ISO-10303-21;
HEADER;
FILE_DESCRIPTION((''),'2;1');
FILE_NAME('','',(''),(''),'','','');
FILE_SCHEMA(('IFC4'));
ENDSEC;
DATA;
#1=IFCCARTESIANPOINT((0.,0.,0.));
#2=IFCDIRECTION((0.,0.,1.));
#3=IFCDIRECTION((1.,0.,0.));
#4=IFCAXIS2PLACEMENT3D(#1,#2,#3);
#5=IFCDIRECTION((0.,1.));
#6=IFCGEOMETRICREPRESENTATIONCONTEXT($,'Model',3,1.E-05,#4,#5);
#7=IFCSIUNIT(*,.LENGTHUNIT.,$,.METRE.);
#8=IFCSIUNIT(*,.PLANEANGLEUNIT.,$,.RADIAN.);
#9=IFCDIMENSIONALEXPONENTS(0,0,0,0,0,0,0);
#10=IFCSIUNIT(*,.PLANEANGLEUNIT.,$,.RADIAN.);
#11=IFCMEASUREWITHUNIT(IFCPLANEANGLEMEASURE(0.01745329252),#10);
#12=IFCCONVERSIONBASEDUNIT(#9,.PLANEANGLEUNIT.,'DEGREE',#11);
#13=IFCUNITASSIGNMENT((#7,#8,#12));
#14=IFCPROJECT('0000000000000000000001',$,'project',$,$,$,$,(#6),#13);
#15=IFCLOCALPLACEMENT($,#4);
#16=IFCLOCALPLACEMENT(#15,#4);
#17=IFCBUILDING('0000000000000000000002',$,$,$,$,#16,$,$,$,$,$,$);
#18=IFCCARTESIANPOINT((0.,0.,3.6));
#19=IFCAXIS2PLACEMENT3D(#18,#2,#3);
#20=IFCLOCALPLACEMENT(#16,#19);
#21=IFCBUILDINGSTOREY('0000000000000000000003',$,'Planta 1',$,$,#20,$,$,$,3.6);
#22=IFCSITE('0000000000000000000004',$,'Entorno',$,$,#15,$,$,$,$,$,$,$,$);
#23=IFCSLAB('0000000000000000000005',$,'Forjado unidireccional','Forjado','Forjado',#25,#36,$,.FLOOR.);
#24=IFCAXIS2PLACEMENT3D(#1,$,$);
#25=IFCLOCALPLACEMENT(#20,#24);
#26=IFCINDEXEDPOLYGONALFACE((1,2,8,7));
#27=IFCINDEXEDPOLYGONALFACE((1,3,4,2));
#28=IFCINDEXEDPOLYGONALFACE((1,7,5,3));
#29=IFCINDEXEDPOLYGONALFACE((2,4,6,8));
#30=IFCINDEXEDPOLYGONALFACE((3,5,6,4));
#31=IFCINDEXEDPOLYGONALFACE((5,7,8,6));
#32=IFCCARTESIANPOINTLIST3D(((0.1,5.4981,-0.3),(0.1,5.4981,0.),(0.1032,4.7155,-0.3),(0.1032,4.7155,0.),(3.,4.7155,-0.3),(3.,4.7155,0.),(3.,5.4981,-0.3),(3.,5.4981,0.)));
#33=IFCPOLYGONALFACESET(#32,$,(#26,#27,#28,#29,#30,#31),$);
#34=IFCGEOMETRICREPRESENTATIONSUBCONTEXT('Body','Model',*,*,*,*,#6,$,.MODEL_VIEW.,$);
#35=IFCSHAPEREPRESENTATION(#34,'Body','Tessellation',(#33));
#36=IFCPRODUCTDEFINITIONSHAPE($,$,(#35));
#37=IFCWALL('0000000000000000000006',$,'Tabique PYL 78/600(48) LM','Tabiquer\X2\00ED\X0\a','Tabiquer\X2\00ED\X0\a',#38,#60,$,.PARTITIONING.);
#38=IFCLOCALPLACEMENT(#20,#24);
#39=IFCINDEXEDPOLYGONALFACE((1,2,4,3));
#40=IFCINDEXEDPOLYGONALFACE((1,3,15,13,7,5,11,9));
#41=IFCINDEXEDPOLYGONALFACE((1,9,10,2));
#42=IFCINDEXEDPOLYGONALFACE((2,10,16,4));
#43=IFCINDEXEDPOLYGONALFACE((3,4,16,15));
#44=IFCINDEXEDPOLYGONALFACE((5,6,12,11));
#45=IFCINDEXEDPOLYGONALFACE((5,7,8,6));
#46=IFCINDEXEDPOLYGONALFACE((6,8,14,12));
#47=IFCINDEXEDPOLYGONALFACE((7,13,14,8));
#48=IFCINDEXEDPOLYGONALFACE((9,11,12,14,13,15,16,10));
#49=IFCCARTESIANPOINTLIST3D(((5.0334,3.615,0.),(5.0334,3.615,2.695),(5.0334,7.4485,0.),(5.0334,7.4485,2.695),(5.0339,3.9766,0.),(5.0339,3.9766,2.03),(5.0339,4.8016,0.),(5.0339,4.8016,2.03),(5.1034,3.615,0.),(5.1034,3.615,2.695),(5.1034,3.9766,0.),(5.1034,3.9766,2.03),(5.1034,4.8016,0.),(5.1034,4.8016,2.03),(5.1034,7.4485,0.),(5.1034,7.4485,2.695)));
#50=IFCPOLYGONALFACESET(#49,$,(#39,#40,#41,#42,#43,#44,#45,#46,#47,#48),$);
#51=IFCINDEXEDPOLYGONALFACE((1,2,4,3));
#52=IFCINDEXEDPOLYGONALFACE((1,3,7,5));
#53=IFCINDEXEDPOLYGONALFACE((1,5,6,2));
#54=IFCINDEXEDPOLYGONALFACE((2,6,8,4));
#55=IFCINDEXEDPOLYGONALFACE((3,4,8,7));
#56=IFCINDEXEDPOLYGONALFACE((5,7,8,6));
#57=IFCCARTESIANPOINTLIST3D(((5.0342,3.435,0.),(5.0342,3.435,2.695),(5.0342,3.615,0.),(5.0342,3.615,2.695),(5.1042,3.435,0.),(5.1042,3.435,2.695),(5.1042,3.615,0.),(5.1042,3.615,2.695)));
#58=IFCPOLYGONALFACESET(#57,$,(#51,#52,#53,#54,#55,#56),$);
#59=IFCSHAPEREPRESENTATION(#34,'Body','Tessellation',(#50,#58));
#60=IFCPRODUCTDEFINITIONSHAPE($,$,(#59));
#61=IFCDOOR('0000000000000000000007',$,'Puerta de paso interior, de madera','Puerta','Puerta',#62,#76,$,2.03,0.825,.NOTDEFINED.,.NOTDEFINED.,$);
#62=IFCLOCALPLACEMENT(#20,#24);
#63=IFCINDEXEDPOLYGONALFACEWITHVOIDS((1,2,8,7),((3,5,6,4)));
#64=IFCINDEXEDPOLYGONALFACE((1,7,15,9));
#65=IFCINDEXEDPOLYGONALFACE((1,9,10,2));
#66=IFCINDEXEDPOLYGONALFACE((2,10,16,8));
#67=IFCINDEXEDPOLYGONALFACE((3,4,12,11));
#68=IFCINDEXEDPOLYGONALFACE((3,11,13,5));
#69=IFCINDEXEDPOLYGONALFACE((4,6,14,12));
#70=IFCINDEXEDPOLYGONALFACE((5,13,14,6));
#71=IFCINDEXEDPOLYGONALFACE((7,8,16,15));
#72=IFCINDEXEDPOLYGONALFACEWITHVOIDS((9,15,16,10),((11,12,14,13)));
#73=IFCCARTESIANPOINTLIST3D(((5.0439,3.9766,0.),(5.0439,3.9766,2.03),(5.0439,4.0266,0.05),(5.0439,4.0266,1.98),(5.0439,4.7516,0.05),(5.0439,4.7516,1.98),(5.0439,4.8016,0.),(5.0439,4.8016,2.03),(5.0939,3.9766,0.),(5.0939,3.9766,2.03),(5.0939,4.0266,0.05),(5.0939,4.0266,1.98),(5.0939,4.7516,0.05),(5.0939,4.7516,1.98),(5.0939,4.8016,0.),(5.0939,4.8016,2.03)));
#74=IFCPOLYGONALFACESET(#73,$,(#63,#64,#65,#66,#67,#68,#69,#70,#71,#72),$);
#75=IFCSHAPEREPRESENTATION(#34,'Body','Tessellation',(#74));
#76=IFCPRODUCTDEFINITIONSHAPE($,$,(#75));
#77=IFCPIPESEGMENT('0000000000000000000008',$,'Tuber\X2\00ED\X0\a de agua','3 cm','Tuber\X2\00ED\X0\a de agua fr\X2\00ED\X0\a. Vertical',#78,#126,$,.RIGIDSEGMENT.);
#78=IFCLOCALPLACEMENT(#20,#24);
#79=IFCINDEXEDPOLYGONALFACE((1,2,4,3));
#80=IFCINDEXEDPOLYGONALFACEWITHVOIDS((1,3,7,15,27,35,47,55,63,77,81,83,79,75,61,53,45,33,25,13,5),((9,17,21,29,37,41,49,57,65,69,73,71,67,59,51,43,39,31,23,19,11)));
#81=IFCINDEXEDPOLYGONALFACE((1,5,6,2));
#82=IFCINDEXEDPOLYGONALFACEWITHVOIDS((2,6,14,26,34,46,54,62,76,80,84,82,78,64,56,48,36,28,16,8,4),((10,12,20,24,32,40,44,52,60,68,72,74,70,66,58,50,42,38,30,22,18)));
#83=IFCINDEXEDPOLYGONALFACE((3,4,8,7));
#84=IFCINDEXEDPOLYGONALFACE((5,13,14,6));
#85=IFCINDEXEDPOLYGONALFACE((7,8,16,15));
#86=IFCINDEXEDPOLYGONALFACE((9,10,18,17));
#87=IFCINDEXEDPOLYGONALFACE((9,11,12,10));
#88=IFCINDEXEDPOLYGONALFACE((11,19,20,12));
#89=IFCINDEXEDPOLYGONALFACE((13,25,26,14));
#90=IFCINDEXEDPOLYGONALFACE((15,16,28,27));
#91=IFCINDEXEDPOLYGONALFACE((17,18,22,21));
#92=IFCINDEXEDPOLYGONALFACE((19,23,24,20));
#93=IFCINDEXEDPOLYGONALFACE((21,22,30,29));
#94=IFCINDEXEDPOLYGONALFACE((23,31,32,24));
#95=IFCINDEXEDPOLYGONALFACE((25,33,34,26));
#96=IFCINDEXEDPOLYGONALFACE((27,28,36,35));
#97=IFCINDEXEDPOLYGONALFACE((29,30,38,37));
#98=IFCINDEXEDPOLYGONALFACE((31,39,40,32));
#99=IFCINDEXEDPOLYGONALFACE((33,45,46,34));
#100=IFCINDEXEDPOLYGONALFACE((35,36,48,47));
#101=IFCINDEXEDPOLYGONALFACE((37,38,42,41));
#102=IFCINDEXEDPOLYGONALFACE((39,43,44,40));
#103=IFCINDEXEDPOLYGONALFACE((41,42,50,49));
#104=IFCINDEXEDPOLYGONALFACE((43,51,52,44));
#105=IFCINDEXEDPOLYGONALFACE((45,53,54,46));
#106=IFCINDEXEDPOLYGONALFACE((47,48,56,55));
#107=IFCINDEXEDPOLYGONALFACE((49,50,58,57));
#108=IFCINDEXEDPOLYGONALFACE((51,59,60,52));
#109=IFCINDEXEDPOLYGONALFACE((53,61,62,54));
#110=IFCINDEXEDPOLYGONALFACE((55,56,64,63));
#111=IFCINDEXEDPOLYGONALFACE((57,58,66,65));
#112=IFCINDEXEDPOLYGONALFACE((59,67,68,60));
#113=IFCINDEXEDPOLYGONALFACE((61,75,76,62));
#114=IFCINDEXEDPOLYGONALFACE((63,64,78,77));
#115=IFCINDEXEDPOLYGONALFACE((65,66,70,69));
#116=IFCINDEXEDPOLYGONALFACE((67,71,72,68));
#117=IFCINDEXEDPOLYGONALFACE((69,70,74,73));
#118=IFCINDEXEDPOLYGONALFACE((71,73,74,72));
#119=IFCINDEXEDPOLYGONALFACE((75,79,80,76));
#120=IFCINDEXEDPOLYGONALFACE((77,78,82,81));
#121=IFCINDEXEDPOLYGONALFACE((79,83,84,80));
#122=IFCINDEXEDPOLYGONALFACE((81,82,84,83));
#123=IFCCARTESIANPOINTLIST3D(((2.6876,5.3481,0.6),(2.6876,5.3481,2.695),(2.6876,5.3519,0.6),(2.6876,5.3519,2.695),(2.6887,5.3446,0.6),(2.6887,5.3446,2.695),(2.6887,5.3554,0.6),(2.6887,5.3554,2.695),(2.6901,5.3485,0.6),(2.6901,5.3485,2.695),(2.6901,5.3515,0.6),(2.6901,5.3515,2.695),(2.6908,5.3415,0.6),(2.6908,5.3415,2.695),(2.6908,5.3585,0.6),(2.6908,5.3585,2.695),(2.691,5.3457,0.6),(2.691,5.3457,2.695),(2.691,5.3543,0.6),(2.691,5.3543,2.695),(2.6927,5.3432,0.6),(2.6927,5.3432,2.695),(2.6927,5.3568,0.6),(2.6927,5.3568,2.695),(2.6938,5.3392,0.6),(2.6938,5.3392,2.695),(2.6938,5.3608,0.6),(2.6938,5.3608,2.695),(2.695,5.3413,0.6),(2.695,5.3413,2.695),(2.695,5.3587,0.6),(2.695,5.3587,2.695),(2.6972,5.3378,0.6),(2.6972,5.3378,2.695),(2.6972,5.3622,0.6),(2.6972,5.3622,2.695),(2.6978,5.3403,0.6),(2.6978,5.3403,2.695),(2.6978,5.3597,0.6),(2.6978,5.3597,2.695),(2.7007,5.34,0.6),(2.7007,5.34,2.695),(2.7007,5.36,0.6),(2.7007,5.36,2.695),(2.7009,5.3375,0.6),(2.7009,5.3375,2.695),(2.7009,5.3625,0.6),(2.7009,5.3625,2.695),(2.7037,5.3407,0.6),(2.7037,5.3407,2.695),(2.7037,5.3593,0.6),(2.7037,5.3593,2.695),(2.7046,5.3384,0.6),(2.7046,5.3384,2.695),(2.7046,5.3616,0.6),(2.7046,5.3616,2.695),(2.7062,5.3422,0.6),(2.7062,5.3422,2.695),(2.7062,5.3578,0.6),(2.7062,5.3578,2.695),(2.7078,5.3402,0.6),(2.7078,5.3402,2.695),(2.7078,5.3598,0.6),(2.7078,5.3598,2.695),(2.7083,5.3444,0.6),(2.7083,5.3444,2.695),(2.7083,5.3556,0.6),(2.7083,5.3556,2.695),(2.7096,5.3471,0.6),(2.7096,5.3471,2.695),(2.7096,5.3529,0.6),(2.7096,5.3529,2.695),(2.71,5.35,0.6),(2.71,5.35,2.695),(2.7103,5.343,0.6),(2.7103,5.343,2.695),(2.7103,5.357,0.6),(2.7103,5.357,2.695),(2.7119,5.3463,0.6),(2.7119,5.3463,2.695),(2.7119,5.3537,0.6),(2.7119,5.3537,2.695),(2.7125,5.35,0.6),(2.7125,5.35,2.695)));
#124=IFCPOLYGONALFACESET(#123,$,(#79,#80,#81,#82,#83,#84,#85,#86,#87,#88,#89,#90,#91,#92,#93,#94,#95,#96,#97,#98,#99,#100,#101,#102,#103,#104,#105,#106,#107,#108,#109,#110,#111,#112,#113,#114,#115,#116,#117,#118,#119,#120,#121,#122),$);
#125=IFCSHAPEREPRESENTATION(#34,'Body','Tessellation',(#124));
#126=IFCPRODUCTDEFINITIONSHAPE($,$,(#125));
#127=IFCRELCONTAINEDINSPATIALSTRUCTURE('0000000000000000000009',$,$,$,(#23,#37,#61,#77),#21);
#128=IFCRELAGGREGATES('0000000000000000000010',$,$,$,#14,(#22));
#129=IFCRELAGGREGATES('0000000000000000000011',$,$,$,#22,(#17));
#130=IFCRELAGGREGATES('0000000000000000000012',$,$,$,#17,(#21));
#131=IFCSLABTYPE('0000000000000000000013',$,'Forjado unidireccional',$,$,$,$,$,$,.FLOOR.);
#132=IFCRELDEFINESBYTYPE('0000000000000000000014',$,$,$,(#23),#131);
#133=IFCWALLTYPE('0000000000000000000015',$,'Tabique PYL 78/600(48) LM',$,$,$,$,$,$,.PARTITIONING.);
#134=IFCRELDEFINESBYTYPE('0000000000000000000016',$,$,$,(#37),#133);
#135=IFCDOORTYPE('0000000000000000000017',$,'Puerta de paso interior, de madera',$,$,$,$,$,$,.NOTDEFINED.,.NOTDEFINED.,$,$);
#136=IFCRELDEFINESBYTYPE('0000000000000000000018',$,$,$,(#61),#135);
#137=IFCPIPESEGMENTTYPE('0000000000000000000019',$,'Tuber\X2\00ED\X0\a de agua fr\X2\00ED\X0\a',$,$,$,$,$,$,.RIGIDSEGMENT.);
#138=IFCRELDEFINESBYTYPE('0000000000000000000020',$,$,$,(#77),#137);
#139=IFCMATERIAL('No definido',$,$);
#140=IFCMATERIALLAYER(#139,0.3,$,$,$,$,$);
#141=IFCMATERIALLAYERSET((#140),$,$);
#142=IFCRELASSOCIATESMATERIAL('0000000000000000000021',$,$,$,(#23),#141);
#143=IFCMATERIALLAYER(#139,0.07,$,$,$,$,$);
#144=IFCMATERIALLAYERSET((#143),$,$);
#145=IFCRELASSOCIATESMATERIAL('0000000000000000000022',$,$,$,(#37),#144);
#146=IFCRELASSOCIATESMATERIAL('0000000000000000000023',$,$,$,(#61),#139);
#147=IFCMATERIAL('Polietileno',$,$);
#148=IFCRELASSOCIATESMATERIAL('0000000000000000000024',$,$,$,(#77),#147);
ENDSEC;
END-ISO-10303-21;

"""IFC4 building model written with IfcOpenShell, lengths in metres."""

from ifc_helpers import new_model, entity, si_unit, converted_unit, direction, frame, origin_with_axes, origin_2d_with_axis, place, context, subcontext, project, spatial, polyline, rectangle, hollow_rectangle, hollow_circle, outline, extrude, shape, material, layer, layer_set, layer_usage, type_object, element, fill, save


model = new_model("IFC4")

# Units and contexts
model_context = context("Model", 3, precision=1e-05, world=origin_with_axes(), true_north=direction((0.0, 1.0)))
body_context = subcontext(model_context, "Body", "Model", "MODEL_VIEW")
footprint_context = subcontext(model_context, "FootPrint", "Model", "MODEL_VIEW")
ifc_project = project(units=[si_unit("LENGTHUNIT", "METRE"), si_unit("PLANEANGLEUNIT", "RADIAN"), converted_unit("PLANEANGLEUNIT", "DEGREE", entity("IfcPlaneAngleMeasure", 0.01745329252), si_unit("PLANEANGLEUNIT", "RADIAN"), dimensions=[0, 0, 0, 0, 0, 0, 0])], contexts=[model_context])

# Site, building, storey
site_placement = place(None, origin_with_axes())
site = spatial("IfcSite", under=ifc_project, at=site_placement, Name="Entorno")
building_placement = place(site_placement, origin_with_axes())
building = spatial("IfcBuilding", under=site, at=building_placement)
storey_placement = place(building_placement, frame((0.0, 0.0, 3.6), z_axis=(0.0, 0.0, 1.0), x_axis=(1.0, 0.0, 0.0)))
storey = spatial("IfcBuildingStorey", under=building, at=storey_placement, Name="Planta 1", Elevation=3.6)

# Slab
ifc_material_1 = material(Name="No definido")
ifc_layer_1 = layer(ifc_material_1, 0.3)
ifc_layer_set_1 = layer_set([ifc_layer_1])
ifc_layer_usage_1 = layer_usage(ifc_layer_set_1, "AXIS3", "POSITIVE", 0.0)
slab_type = type_object("IfcSlabType", Name="Forjado unidireccional", PredefinedType="FLOOR")
slab_placement = place(storey_placement, frame((3.0, 5.4981, -0.3), z_axis=(0.0, 0.0, 1.0), x_axis=(1.0, 0.0, 0.0)))
element("IfcSlab", 1, at=slab_placement, inside=storey, type_object=slab_type, material=ifc_layer_usage_1, Name="Forjado unidireccional", Description="Forjado", ObjectType="Forjado", PredefinedType="FLOOR", context=body_context, shape_type="SweptSolid", body=[
    extrude(outline(polyline([(0.0, 0.0), (-2.9, 0.0), (-2.8968, -0.7826), (0.0, -0.7826), (0.0, 0.0)])), origin_with_axes(), (0.0, 0.0, 1.0), 0.3),
])

# Wall, opening, door
ifc_layer_2 = layer(ifc_material_1, 0.07)
ifc_layer_set_2 = layer_set([ifc_layer_2])
ifc_layer_usage_2 = layer_usage(ifc_layer_set_2, "AXIS2", "POSITIVE", -0.035)
wall_type_1 = type_object("IfcWallType", Name="Tabique PYL 78/600(48) LM", PredefinedType="PARTITIONING")
wall_1_placement = place(storey_placement, frame((5.0692, 7.6, 0.0), z_axis=(0.0, 0.0, 1.0), x_axis=(0.0, -1.0, 0.0)))
cartesian_point_1 = entity("IfcCartesianPoint", [-1.9167, -1.3475])
cartesian_point_2 = entity("IfcCartesianPoint", [-1.9167, -1.3475])
cartesian_point_3 = entity("IfcCartesianPoint", [-0.09, -1.3475])
cartesian_point_4 = entity("IfcCartesianPoint", [-0.09, -1.3475])
wall_1 = element("IfcWall", 2, at=wall_1_placement, inside=storey, type_object=wall_type_1, material=ifc_layer_usage_2, Name="Tabique PYL 78/600(48) LM", Description="Tabiquería", ObjectType="Tabiquería", PredefinedType="PARTITIONING", context=body_context, shape_type="SolidModel", body=[
    entity("IfcExtrudedAreaSolidTapered", entity("IfcArbitraryClosedProfileDef", "AREA", None, entity("IfcPolyline", [cartesian_point_1, entity("IfcCartesianPoint", [1.9167, -1.3475]), entity("IfcCartesianPoint", [1.9167, 1.3475]), entity("IfcCartesianPoint", [-1.9167, 1.3475]), cartesian_point_1])), entity("IfcAxis2Placement3D", entity("IfcCartesianPoint", [2.0682, 0.0342, 1.3475]), entity("IfcDirection", [0.0, -1.0, 0.0]), entity("IfcDirection", [1.0, 0.0, 0.0])), entity("IfcDirection", [0.0, 0.0, 1.0]), 0.07, entity("IfcArbitraryClosedProfileDef", "AREA", None, entity("IfcPolyline", [cartesian_point_2, entity("IfcCartesianPoint", [1.9167, -1.3475]), entity("IfcCartesianPoint", [1.9167, 1.3475]), entity("IfcCartesianPoint", [-1.9167, 1.3475]), cartesian_point_2]))),
    entity("IfcExtrudedAreaSolidTapered", entity("IfcArbitraryClosedProfileDef", "AREA", None, entity("IfcPolyline", [cartesian_point_3, entity("IfcCartesianPoint", [0.09, -1.3475]), entity("IfcCartesianPoint", [0.09, 1.3475]), entity("IfcCartesianPoint", [-0.09, 1.3475]), cartesian_point_3])), entity("IfcAxis2Placement3D", entity("IfcCartesianPoint", [4.075, 0.035, 1.3475]), entity("IfcDirection", [0.0, -1.0, 0.0]), entity("IfcDirection", [1.0, 0.0, 0.0])), entity("IfcDirection", [0.0, 0.0, 1.0]), 0.07, entity("IfcArbitraryClosedProfileDef", "AREA", None, entity("IfcPolyline", [cartesian_point_4, entity("IfcCartesianPoint", [0.09, -1.3475]), entity("IfcCartesianPoint", [0.09, 1.3475]), entity("IfcCartesianPoint", [-0.09, 1.3475]), cartesian_point_4]))),
])
opening_1_placement = place(wall_1_placement, frame((3.2109, -0.0003, 1.015), z_axis=(0.0, 0.0, 1.0), x_axis=(1.0, 0.0, 0.0)))
cartesian_point_5 = entity("IfcCartesianPoint", [-0.4125, -0.035])
opening_1 = element("IfcOpeningElement", 3, at=opening_1_placement, cuts=wall_1, ObjectType="No definido", PredefinedType="OPENING", shapes=[
    shape(body_context, "Body", "SweptSolid", [extrude(rectangle(XDim=2.03, YDim=0.825, at=origin_2d_with_axis()), frame((0.0, -0.035, 0.0), z_axis=(0.0, 1.0, 0.0), x_axis=(0.0, 0.0, 1.0)), (0.0, 0.0, 1.0), 0.07)]),
    shape(footprint_context, "FootPrint", "GeometricCurveSet", [entity("IfcGeometricCurveSet", [entity("IfcPolyline", [cartesian_point_5, entity("IfcCartesianPoint", [0.4125, -0.035]), entity("IfcCartesianPoint", [0.4125, 0.035]), entity("IfcCartesianPoint", [-0.4125, 0.035]), cartesian_point_5])])]),
])
door_type = type_object("IfcDoorType", Name="Puerta de paso interior, de madera", OperationType="NOTDEFINED", PredefinedType="NOTDEFINED")
door_placement = place(opening_1_placement, origin_with_axes())
door = element("IfcDoor", 4, at=door_placement, inside=storey, type_object=door_type, material=ifc_material_1, Name="Puerta de paso interior, de madera", Description="Puerta", ObjectType="Puerta", OperationType="NOTDEFINED", OverallHeight=2.03, OverallWidth=0.825, PredefinedType="NOTDEFINED", context=body_context, shape_type="SweptSolid", body=[
    extrude(hollow_rectangle(XDim=0.825, YDim=2.03, WallThickness=0.05, InnerFilletRadius=0.0, OuterFilletRadius=0.0, at=origin_2d_with_axis()), frame((0.0, 0.025, 0.0), z_axis=(0.0, -1.0, 0.0), x_axis=(1.0, 0.0, 0.0)), (0.0, 0.0, 1.0), 0.05),
])
fill(opening_1, door)

# Pipe segment
ifc_material_2 = material(Name="Polietileno")
pipe_segment_type_1 = type_object("IfcPipeSegmentType", Name="Tubería de agua fría", PredefinedType="RIGIDSEGMENT")
pipe_segment_1_placement = place(storey_placement, frame((2.7, 5.35, 2.695), z_axis=(0.0, 0.0, -1.0), x_axis=(1.0, 0.0, 0.0)))
element("IfcPipeSegment", 5, at=pipe_segment_1_placement, inside=storey, type_object=pipe_segment_type_1, material=ifc_material_2, Name="Tubería de agua", Description="3 cm", ObjectType="Tubería de agua fría. Vertical", PredefinedType="RIGIDSEGMENT", context=body_context, shape_type="SweptSolid", body=[
    extrude(hollow_circle(Radius=0.0125, WallThickness=0.0025, at=origin_2d_with_axis()), origin_with_axes(), (0.0, 0.0, 1.0), 2.095),
])

save(model, "model.ifc")
